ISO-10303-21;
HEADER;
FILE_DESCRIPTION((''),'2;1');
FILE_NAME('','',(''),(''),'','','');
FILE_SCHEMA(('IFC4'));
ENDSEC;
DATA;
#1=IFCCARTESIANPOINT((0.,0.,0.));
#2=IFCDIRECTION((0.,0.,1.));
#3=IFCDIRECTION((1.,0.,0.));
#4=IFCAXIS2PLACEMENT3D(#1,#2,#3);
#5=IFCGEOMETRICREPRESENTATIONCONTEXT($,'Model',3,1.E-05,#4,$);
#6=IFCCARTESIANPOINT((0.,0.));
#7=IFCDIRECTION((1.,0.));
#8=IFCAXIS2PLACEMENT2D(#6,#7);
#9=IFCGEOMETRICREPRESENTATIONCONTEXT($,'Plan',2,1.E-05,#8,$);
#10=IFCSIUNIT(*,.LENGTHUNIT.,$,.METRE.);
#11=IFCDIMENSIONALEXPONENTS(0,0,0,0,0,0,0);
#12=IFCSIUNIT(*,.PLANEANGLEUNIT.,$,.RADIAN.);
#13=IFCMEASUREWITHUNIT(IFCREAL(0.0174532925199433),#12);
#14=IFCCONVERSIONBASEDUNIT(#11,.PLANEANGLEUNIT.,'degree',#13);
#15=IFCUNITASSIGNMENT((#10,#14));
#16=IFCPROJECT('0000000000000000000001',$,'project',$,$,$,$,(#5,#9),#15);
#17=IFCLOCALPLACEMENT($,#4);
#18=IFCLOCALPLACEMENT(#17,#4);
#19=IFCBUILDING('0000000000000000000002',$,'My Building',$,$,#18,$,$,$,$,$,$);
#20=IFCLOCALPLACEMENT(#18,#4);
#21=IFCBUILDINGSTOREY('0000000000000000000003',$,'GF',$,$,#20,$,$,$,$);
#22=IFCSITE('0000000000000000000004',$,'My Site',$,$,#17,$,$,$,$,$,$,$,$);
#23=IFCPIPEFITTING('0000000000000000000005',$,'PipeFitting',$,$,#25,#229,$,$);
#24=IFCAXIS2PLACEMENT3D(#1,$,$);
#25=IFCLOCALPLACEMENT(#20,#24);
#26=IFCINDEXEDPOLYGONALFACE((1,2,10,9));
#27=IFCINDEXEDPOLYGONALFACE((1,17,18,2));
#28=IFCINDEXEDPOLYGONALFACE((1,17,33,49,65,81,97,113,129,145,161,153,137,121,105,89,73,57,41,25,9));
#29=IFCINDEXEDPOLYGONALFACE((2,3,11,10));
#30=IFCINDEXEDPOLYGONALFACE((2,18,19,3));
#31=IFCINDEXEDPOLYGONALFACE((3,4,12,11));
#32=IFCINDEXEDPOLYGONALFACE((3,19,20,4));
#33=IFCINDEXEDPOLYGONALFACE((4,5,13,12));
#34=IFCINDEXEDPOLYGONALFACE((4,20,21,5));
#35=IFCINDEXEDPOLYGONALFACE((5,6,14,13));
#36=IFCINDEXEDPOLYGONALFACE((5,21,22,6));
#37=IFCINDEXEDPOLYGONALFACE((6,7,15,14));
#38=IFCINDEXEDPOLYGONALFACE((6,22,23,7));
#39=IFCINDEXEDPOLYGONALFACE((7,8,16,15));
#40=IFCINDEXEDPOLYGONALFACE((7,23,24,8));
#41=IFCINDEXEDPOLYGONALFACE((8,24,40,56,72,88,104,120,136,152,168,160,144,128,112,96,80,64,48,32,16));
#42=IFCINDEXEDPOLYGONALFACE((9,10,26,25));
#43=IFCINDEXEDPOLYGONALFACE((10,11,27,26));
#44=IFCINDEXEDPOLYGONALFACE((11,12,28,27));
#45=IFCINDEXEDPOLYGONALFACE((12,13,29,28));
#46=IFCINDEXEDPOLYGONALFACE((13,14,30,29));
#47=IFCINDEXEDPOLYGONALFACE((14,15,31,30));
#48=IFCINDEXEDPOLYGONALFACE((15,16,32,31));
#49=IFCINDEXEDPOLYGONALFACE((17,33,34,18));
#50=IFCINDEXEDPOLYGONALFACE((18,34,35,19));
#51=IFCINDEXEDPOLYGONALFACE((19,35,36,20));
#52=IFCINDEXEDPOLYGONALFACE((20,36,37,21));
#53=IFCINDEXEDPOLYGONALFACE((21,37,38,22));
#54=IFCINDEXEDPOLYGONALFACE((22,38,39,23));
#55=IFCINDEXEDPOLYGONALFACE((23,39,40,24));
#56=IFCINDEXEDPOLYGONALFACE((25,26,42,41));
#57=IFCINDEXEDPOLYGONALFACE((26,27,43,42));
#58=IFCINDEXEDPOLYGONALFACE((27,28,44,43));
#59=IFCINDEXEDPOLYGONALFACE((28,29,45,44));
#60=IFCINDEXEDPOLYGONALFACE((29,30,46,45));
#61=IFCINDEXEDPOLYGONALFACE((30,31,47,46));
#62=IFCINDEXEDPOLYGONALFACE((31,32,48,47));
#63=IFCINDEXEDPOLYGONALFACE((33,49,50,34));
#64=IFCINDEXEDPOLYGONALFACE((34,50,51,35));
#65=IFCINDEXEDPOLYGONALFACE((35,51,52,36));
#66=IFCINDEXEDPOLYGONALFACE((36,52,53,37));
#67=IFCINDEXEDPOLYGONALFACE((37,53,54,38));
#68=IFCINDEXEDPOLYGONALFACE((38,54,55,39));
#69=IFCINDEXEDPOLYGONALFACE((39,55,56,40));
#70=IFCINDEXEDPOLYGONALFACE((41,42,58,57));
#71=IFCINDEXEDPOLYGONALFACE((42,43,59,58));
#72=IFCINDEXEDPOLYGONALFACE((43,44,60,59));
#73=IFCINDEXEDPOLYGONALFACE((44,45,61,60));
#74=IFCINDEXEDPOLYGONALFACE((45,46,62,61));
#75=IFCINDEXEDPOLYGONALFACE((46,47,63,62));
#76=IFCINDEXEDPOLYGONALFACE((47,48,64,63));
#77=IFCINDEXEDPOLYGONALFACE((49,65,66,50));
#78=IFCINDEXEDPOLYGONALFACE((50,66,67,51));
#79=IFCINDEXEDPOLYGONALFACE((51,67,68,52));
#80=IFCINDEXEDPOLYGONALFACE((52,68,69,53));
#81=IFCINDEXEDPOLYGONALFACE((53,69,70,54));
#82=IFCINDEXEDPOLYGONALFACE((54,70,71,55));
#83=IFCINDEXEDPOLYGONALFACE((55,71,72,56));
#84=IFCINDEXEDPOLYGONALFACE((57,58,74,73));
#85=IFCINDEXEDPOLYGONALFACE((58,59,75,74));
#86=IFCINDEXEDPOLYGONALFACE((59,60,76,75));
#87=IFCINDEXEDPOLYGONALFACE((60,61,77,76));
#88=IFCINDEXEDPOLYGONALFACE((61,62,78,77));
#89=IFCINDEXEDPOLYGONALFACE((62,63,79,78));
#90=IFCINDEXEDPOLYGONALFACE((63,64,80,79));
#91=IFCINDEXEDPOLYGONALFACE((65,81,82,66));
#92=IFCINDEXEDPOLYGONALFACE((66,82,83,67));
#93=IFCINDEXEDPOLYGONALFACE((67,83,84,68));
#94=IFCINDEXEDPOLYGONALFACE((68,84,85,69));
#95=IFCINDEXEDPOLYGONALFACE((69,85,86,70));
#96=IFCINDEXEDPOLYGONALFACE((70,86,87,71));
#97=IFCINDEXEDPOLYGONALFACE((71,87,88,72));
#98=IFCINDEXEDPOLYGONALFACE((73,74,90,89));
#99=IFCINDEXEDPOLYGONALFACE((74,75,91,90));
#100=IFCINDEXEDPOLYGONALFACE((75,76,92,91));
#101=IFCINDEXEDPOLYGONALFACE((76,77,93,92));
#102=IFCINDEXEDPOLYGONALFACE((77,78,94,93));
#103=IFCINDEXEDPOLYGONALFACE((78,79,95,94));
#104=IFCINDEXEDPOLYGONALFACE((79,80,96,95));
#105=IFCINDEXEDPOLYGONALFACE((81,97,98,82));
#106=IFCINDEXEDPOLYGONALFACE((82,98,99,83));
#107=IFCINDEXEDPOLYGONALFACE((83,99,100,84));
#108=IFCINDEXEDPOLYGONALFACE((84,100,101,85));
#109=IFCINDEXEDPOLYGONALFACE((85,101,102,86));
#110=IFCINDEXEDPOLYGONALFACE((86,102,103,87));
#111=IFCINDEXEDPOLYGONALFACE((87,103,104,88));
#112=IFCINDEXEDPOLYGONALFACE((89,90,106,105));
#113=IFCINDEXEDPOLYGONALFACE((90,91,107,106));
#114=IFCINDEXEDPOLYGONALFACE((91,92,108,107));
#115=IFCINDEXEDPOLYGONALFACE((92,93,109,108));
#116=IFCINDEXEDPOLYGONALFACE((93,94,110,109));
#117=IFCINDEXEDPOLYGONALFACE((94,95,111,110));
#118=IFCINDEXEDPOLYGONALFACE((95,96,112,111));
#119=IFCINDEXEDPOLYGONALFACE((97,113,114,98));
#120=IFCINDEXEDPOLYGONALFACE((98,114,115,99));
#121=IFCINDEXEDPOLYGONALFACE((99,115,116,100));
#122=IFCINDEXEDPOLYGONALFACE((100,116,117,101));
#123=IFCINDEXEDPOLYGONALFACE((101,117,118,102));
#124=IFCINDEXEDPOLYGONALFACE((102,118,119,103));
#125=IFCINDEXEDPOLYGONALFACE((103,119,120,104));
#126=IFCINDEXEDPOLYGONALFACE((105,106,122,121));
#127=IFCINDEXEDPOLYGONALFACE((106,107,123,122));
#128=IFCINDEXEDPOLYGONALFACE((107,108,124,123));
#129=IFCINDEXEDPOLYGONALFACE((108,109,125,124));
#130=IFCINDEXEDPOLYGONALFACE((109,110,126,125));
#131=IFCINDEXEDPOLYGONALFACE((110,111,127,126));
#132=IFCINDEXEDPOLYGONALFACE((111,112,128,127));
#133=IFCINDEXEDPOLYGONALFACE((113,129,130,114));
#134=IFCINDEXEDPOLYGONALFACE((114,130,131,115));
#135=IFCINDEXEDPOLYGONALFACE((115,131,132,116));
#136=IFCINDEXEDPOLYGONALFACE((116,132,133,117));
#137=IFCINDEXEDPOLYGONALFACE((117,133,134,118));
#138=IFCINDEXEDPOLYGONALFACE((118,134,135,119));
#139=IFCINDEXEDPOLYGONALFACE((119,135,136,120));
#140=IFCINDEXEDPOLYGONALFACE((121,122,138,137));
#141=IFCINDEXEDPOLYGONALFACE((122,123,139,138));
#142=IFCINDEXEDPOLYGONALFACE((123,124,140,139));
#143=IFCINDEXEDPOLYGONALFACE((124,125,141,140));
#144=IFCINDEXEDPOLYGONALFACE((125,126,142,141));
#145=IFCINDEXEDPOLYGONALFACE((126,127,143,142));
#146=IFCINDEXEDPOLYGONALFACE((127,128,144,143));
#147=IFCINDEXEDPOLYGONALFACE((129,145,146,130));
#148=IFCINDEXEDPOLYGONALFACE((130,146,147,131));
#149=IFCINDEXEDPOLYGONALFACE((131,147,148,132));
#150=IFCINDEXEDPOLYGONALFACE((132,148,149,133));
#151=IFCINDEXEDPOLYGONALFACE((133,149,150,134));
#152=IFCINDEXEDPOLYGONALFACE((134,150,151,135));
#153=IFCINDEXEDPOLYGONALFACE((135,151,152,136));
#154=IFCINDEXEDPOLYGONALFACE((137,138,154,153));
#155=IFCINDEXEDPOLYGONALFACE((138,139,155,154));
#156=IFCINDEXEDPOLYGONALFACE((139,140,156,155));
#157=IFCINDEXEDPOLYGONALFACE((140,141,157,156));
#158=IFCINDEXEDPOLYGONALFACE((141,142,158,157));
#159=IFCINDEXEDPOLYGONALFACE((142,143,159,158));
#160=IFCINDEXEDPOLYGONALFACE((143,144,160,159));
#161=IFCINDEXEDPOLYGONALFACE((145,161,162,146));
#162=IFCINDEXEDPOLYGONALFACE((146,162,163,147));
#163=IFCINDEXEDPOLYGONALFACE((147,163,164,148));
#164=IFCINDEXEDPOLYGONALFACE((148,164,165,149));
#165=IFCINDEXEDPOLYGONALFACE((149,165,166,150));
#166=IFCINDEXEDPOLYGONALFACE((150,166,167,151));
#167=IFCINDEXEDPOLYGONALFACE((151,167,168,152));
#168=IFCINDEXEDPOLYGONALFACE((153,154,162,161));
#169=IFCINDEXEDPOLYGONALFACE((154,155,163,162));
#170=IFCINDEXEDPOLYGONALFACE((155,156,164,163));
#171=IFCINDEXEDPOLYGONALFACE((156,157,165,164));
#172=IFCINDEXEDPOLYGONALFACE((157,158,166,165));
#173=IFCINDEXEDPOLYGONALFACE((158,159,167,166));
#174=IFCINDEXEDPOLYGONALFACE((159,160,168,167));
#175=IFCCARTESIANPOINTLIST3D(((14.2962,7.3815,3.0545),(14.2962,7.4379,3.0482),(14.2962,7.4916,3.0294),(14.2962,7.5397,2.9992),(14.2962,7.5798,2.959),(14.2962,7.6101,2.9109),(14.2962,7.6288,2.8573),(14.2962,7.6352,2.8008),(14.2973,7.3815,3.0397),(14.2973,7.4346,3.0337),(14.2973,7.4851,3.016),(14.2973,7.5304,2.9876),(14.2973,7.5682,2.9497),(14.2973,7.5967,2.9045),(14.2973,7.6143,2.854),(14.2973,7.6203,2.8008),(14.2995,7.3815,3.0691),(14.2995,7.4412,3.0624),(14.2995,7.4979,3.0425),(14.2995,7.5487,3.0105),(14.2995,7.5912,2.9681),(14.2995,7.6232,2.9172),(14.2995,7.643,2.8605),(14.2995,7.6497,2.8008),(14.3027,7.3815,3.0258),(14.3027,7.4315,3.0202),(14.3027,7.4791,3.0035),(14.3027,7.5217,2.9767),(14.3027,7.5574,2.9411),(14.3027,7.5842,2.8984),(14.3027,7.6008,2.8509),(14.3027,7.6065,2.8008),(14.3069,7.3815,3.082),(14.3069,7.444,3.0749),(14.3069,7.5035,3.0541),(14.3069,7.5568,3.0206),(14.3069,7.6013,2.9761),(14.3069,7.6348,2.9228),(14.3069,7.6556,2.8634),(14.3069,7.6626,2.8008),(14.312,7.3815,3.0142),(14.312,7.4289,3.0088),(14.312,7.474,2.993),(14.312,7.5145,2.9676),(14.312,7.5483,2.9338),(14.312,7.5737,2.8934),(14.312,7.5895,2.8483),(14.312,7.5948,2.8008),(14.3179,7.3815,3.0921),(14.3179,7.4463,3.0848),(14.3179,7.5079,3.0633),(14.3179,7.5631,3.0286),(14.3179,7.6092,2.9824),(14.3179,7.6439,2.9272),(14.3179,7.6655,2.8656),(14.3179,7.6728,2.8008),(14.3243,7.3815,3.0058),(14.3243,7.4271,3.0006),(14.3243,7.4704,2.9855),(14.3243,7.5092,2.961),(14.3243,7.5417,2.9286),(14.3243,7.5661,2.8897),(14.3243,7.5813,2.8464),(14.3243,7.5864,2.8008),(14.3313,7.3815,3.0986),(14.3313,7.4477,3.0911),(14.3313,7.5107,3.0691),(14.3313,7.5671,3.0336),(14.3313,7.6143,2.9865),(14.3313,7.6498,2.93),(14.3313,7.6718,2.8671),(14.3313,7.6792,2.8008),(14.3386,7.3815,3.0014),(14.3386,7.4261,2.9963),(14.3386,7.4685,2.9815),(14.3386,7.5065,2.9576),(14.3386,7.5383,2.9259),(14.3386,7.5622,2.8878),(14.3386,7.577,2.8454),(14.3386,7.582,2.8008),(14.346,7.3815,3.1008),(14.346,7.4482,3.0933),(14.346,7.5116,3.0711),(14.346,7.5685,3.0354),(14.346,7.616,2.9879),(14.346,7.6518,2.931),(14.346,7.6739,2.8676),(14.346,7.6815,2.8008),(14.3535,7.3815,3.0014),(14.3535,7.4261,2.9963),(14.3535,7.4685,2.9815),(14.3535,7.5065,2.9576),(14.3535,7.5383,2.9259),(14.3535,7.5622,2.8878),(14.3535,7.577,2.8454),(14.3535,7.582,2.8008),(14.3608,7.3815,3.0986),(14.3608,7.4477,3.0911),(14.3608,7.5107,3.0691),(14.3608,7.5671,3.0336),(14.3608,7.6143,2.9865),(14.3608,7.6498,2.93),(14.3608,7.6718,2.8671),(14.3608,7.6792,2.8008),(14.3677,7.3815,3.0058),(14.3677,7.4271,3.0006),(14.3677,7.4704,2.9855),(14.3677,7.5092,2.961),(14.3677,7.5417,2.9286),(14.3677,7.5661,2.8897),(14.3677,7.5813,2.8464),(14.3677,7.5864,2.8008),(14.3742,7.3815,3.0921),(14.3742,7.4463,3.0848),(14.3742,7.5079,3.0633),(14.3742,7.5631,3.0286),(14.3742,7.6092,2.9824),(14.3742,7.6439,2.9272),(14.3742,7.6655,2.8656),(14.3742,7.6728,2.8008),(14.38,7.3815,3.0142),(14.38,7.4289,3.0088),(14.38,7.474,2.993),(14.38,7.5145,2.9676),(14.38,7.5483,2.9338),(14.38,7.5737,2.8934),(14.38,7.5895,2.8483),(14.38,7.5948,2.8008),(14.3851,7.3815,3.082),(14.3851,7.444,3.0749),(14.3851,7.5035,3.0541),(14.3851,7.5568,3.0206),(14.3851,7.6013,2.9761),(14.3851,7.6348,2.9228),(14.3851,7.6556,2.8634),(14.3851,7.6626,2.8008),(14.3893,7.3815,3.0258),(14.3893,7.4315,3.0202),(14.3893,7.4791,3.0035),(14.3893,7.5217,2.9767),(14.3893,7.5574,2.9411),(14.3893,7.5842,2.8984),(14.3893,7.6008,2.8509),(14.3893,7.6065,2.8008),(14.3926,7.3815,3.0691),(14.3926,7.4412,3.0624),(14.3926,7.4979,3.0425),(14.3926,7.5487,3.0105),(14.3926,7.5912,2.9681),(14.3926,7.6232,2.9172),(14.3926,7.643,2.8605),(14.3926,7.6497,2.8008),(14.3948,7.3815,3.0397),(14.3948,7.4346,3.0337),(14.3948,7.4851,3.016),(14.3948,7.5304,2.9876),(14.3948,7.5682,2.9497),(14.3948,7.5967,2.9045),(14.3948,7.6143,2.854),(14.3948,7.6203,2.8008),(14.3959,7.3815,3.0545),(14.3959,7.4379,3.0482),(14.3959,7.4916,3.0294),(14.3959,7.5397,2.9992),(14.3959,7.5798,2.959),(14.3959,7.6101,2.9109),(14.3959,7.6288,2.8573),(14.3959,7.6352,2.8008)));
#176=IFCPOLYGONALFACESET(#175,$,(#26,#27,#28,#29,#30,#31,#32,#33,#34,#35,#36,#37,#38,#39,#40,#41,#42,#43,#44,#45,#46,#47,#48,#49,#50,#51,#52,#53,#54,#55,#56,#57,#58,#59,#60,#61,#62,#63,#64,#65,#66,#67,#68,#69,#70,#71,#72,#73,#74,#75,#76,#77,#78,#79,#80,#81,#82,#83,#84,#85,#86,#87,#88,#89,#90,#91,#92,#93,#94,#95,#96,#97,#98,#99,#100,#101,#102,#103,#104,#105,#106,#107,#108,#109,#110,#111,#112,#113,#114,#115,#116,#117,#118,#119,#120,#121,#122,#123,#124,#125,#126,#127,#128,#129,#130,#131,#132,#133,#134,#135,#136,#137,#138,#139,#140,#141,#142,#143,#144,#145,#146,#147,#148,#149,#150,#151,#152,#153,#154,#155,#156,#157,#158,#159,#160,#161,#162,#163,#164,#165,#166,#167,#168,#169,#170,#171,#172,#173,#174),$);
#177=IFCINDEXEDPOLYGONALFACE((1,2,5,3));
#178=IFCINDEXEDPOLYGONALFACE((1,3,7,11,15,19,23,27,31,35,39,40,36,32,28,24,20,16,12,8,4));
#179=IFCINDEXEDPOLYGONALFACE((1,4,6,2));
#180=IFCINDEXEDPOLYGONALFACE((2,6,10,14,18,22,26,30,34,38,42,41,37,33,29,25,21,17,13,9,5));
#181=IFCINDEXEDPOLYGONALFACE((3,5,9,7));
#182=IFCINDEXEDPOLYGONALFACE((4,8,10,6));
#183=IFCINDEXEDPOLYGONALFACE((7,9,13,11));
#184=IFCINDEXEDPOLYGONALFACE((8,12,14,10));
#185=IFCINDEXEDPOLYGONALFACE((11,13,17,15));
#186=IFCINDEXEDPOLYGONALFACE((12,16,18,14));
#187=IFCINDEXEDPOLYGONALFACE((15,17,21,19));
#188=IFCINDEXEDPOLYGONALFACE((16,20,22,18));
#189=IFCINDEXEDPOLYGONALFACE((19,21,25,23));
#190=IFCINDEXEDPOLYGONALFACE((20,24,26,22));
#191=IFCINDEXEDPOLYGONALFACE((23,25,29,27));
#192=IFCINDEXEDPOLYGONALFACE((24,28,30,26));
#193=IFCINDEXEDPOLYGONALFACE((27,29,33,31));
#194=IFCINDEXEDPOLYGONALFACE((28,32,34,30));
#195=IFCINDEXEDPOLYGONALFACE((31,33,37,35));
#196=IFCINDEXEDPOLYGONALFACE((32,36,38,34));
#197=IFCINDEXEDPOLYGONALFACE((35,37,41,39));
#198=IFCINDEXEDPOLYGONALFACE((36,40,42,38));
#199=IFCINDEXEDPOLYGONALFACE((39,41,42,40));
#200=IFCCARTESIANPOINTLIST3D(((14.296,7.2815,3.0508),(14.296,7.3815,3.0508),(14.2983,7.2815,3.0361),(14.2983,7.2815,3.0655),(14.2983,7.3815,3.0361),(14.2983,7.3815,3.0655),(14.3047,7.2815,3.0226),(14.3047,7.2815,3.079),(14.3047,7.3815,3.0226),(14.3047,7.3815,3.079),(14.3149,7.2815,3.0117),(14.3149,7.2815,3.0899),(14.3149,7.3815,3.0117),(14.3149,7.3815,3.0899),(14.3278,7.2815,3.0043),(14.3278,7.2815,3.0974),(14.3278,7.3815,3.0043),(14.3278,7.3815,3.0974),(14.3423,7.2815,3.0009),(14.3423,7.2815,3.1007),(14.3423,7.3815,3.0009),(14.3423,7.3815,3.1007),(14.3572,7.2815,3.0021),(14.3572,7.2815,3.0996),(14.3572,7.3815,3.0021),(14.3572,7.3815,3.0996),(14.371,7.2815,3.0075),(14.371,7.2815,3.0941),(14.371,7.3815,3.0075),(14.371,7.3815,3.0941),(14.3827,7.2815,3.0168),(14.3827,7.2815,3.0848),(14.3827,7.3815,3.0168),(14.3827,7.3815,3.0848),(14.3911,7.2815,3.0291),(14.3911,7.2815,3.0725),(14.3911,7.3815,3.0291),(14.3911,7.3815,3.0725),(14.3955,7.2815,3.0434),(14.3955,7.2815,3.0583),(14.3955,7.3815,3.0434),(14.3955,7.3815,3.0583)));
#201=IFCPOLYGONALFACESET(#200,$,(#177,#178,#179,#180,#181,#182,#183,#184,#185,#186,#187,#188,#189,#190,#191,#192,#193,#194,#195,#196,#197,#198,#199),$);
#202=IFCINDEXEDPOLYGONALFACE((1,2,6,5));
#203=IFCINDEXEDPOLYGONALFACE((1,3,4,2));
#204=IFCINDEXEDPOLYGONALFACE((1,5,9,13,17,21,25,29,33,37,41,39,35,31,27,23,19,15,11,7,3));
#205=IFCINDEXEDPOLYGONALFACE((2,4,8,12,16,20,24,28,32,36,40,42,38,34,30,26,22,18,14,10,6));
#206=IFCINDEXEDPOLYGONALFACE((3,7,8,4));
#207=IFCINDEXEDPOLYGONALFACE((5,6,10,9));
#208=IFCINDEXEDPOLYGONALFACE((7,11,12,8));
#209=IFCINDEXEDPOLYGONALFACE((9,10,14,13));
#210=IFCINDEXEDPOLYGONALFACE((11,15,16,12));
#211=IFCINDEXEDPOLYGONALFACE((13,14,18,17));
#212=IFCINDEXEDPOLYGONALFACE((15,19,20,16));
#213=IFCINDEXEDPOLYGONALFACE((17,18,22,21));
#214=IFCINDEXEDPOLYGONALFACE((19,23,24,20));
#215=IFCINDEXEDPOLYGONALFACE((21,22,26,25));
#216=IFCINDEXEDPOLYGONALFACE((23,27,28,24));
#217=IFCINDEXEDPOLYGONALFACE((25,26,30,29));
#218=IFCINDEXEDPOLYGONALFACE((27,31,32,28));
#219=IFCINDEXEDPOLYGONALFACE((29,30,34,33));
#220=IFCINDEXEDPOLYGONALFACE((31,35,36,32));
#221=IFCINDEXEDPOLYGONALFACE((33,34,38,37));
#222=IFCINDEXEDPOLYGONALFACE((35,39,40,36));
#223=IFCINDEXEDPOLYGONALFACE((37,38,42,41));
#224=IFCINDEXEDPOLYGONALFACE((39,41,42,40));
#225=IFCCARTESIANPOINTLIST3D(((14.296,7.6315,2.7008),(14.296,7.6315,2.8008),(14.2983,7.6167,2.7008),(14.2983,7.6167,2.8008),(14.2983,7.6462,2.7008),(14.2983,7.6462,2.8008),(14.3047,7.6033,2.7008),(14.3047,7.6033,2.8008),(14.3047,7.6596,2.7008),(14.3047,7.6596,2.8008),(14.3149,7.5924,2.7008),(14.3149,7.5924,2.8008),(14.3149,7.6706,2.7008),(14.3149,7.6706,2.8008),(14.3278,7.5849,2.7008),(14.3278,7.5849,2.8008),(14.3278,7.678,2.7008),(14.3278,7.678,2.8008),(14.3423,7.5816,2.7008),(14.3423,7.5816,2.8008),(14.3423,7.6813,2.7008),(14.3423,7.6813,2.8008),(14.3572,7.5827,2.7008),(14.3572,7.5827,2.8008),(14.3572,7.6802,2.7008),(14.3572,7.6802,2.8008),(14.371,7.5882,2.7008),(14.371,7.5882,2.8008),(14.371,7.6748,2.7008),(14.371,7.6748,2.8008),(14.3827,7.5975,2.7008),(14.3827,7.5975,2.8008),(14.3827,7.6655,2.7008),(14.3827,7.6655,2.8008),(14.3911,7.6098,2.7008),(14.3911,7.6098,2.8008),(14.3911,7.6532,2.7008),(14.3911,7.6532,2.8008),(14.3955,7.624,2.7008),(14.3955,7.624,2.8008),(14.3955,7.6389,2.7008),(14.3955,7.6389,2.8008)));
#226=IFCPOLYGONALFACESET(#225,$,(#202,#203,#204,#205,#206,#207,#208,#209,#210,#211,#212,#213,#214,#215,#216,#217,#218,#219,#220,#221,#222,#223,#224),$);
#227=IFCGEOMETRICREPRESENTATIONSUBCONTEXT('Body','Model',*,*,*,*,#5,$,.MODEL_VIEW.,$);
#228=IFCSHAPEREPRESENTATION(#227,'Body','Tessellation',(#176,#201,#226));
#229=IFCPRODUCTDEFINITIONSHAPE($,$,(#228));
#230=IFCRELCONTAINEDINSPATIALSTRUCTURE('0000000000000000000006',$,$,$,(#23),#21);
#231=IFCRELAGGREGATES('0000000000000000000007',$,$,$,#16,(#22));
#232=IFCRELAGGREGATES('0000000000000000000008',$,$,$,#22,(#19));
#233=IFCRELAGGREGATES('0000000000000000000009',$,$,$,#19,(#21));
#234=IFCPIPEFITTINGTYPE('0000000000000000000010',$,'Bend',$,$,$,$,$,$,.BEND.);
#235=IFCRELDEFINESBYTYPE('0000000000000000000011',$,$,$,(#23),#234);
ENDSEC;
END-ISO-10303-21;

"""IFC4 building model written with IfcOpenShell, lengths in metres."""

from ifc_helpers import new_model, entity, si_unit, converted_unit, frame, origin_with_axes, origin_2d_with_axis, place, context, subcontext, project, spatial, circle, extrude, source, transform, mapped, type_object, type_shapes, element, save


model = new_model("IFC4")

# Units and contexts
model_context = context("Model", 3, precision=1e-05, world=origin_with_axes())
plan_context = context("Plan", 2, precision=1e-05, world=origin_2d_with_axis())
body_context_1 = subcontext(model_context, "Body", "Model", "MODEL_VIEW")
ifc_project = project(units=[si_unit("LENGTHUNIT", "METRE"), converted_unit("PLANEANGLEUNIT", "degree", entity("IfcReal", 0.0174532925199433), si_unit("PLANEANGLEUNIT", "RADIAN"), dimensions=[0, 0, 0, 0, 0, 0, 0])], contexts=[model_context, plan_context])

# Site, building, storey
site_placement = place(None, origin_with_axes())
site = spatial("IfcSite", under=ifc_project, at=site_placement, Name="My Site")
building_placement = place(site_placement, origin_with_axes())
building = spatial("IfcBuilding", under=site, at=building_placement, Name="My Building")
storey_placement = place(building_placement, origin_with_axes())
storey = spatial("IfcBuildingStorey", under=building, at=storey_placement, Name="GF")

# Pipe fitting
pipe_fitting_type = type_object("IfcPipeFittingType", Name="Bend", PredefinedType="BEND")
shared_shape_1 = source(origin_with_axes(), body_context_1, "Body", "SolidModel", [
    entity("IfcSweptDiskSolid", entity("IfcIndexedPolyCurve", entity("IfcCartesianPointList3D", [[0.0, 0.0, 0.1], [0.0, -0.0732, 0.2768], [0.0, -0.25, 0.35]]), [entity("IfcArcIndex", [1, 2, 3])]), 0.05),
    extrude(circle(Radius=0.05), origin_with_axes(), (0.0, 0.0, 1.0), 0.1),
    extrude(circle(Radius=0.05), frame((0.0, -0.25, 0.35), z_axis=(0.0, -1.0, 0.0), x_axis=(1.0, 0.0, 0.0)), (0.0, 0.0, 1.0), 0.1),
])
type_shapes(pipe_fitting_type, [shared_shape_1])
for number, where, z_axis, x_axis, name in (
    (1, (14.346, 7.2815, 3.0508), (0.0, 1.0, 0.0), (-1.0, 0.0, 0.0), "PipeFitting"),
):
    element("IfcPipeFitting", number, at=place(storey_placement, frame(where, z_axis=z_axis, x_axis=x_axis)), inside=storey, type_object=pipe_fitting_type, Name=name, context=body_context_1, shape_type="MappedRepresentation", body=[
        mapped(shared_shape_1, transform((0.0, 0.0, 0.0), x_axis=(1.0, 0.0, 0.0), y_axis=(0.0, 1.0, 0.0), z_axis=(0.0, 0.0, 1.0), scale=1.0)),
    ])

save(model, "model.ifc")
